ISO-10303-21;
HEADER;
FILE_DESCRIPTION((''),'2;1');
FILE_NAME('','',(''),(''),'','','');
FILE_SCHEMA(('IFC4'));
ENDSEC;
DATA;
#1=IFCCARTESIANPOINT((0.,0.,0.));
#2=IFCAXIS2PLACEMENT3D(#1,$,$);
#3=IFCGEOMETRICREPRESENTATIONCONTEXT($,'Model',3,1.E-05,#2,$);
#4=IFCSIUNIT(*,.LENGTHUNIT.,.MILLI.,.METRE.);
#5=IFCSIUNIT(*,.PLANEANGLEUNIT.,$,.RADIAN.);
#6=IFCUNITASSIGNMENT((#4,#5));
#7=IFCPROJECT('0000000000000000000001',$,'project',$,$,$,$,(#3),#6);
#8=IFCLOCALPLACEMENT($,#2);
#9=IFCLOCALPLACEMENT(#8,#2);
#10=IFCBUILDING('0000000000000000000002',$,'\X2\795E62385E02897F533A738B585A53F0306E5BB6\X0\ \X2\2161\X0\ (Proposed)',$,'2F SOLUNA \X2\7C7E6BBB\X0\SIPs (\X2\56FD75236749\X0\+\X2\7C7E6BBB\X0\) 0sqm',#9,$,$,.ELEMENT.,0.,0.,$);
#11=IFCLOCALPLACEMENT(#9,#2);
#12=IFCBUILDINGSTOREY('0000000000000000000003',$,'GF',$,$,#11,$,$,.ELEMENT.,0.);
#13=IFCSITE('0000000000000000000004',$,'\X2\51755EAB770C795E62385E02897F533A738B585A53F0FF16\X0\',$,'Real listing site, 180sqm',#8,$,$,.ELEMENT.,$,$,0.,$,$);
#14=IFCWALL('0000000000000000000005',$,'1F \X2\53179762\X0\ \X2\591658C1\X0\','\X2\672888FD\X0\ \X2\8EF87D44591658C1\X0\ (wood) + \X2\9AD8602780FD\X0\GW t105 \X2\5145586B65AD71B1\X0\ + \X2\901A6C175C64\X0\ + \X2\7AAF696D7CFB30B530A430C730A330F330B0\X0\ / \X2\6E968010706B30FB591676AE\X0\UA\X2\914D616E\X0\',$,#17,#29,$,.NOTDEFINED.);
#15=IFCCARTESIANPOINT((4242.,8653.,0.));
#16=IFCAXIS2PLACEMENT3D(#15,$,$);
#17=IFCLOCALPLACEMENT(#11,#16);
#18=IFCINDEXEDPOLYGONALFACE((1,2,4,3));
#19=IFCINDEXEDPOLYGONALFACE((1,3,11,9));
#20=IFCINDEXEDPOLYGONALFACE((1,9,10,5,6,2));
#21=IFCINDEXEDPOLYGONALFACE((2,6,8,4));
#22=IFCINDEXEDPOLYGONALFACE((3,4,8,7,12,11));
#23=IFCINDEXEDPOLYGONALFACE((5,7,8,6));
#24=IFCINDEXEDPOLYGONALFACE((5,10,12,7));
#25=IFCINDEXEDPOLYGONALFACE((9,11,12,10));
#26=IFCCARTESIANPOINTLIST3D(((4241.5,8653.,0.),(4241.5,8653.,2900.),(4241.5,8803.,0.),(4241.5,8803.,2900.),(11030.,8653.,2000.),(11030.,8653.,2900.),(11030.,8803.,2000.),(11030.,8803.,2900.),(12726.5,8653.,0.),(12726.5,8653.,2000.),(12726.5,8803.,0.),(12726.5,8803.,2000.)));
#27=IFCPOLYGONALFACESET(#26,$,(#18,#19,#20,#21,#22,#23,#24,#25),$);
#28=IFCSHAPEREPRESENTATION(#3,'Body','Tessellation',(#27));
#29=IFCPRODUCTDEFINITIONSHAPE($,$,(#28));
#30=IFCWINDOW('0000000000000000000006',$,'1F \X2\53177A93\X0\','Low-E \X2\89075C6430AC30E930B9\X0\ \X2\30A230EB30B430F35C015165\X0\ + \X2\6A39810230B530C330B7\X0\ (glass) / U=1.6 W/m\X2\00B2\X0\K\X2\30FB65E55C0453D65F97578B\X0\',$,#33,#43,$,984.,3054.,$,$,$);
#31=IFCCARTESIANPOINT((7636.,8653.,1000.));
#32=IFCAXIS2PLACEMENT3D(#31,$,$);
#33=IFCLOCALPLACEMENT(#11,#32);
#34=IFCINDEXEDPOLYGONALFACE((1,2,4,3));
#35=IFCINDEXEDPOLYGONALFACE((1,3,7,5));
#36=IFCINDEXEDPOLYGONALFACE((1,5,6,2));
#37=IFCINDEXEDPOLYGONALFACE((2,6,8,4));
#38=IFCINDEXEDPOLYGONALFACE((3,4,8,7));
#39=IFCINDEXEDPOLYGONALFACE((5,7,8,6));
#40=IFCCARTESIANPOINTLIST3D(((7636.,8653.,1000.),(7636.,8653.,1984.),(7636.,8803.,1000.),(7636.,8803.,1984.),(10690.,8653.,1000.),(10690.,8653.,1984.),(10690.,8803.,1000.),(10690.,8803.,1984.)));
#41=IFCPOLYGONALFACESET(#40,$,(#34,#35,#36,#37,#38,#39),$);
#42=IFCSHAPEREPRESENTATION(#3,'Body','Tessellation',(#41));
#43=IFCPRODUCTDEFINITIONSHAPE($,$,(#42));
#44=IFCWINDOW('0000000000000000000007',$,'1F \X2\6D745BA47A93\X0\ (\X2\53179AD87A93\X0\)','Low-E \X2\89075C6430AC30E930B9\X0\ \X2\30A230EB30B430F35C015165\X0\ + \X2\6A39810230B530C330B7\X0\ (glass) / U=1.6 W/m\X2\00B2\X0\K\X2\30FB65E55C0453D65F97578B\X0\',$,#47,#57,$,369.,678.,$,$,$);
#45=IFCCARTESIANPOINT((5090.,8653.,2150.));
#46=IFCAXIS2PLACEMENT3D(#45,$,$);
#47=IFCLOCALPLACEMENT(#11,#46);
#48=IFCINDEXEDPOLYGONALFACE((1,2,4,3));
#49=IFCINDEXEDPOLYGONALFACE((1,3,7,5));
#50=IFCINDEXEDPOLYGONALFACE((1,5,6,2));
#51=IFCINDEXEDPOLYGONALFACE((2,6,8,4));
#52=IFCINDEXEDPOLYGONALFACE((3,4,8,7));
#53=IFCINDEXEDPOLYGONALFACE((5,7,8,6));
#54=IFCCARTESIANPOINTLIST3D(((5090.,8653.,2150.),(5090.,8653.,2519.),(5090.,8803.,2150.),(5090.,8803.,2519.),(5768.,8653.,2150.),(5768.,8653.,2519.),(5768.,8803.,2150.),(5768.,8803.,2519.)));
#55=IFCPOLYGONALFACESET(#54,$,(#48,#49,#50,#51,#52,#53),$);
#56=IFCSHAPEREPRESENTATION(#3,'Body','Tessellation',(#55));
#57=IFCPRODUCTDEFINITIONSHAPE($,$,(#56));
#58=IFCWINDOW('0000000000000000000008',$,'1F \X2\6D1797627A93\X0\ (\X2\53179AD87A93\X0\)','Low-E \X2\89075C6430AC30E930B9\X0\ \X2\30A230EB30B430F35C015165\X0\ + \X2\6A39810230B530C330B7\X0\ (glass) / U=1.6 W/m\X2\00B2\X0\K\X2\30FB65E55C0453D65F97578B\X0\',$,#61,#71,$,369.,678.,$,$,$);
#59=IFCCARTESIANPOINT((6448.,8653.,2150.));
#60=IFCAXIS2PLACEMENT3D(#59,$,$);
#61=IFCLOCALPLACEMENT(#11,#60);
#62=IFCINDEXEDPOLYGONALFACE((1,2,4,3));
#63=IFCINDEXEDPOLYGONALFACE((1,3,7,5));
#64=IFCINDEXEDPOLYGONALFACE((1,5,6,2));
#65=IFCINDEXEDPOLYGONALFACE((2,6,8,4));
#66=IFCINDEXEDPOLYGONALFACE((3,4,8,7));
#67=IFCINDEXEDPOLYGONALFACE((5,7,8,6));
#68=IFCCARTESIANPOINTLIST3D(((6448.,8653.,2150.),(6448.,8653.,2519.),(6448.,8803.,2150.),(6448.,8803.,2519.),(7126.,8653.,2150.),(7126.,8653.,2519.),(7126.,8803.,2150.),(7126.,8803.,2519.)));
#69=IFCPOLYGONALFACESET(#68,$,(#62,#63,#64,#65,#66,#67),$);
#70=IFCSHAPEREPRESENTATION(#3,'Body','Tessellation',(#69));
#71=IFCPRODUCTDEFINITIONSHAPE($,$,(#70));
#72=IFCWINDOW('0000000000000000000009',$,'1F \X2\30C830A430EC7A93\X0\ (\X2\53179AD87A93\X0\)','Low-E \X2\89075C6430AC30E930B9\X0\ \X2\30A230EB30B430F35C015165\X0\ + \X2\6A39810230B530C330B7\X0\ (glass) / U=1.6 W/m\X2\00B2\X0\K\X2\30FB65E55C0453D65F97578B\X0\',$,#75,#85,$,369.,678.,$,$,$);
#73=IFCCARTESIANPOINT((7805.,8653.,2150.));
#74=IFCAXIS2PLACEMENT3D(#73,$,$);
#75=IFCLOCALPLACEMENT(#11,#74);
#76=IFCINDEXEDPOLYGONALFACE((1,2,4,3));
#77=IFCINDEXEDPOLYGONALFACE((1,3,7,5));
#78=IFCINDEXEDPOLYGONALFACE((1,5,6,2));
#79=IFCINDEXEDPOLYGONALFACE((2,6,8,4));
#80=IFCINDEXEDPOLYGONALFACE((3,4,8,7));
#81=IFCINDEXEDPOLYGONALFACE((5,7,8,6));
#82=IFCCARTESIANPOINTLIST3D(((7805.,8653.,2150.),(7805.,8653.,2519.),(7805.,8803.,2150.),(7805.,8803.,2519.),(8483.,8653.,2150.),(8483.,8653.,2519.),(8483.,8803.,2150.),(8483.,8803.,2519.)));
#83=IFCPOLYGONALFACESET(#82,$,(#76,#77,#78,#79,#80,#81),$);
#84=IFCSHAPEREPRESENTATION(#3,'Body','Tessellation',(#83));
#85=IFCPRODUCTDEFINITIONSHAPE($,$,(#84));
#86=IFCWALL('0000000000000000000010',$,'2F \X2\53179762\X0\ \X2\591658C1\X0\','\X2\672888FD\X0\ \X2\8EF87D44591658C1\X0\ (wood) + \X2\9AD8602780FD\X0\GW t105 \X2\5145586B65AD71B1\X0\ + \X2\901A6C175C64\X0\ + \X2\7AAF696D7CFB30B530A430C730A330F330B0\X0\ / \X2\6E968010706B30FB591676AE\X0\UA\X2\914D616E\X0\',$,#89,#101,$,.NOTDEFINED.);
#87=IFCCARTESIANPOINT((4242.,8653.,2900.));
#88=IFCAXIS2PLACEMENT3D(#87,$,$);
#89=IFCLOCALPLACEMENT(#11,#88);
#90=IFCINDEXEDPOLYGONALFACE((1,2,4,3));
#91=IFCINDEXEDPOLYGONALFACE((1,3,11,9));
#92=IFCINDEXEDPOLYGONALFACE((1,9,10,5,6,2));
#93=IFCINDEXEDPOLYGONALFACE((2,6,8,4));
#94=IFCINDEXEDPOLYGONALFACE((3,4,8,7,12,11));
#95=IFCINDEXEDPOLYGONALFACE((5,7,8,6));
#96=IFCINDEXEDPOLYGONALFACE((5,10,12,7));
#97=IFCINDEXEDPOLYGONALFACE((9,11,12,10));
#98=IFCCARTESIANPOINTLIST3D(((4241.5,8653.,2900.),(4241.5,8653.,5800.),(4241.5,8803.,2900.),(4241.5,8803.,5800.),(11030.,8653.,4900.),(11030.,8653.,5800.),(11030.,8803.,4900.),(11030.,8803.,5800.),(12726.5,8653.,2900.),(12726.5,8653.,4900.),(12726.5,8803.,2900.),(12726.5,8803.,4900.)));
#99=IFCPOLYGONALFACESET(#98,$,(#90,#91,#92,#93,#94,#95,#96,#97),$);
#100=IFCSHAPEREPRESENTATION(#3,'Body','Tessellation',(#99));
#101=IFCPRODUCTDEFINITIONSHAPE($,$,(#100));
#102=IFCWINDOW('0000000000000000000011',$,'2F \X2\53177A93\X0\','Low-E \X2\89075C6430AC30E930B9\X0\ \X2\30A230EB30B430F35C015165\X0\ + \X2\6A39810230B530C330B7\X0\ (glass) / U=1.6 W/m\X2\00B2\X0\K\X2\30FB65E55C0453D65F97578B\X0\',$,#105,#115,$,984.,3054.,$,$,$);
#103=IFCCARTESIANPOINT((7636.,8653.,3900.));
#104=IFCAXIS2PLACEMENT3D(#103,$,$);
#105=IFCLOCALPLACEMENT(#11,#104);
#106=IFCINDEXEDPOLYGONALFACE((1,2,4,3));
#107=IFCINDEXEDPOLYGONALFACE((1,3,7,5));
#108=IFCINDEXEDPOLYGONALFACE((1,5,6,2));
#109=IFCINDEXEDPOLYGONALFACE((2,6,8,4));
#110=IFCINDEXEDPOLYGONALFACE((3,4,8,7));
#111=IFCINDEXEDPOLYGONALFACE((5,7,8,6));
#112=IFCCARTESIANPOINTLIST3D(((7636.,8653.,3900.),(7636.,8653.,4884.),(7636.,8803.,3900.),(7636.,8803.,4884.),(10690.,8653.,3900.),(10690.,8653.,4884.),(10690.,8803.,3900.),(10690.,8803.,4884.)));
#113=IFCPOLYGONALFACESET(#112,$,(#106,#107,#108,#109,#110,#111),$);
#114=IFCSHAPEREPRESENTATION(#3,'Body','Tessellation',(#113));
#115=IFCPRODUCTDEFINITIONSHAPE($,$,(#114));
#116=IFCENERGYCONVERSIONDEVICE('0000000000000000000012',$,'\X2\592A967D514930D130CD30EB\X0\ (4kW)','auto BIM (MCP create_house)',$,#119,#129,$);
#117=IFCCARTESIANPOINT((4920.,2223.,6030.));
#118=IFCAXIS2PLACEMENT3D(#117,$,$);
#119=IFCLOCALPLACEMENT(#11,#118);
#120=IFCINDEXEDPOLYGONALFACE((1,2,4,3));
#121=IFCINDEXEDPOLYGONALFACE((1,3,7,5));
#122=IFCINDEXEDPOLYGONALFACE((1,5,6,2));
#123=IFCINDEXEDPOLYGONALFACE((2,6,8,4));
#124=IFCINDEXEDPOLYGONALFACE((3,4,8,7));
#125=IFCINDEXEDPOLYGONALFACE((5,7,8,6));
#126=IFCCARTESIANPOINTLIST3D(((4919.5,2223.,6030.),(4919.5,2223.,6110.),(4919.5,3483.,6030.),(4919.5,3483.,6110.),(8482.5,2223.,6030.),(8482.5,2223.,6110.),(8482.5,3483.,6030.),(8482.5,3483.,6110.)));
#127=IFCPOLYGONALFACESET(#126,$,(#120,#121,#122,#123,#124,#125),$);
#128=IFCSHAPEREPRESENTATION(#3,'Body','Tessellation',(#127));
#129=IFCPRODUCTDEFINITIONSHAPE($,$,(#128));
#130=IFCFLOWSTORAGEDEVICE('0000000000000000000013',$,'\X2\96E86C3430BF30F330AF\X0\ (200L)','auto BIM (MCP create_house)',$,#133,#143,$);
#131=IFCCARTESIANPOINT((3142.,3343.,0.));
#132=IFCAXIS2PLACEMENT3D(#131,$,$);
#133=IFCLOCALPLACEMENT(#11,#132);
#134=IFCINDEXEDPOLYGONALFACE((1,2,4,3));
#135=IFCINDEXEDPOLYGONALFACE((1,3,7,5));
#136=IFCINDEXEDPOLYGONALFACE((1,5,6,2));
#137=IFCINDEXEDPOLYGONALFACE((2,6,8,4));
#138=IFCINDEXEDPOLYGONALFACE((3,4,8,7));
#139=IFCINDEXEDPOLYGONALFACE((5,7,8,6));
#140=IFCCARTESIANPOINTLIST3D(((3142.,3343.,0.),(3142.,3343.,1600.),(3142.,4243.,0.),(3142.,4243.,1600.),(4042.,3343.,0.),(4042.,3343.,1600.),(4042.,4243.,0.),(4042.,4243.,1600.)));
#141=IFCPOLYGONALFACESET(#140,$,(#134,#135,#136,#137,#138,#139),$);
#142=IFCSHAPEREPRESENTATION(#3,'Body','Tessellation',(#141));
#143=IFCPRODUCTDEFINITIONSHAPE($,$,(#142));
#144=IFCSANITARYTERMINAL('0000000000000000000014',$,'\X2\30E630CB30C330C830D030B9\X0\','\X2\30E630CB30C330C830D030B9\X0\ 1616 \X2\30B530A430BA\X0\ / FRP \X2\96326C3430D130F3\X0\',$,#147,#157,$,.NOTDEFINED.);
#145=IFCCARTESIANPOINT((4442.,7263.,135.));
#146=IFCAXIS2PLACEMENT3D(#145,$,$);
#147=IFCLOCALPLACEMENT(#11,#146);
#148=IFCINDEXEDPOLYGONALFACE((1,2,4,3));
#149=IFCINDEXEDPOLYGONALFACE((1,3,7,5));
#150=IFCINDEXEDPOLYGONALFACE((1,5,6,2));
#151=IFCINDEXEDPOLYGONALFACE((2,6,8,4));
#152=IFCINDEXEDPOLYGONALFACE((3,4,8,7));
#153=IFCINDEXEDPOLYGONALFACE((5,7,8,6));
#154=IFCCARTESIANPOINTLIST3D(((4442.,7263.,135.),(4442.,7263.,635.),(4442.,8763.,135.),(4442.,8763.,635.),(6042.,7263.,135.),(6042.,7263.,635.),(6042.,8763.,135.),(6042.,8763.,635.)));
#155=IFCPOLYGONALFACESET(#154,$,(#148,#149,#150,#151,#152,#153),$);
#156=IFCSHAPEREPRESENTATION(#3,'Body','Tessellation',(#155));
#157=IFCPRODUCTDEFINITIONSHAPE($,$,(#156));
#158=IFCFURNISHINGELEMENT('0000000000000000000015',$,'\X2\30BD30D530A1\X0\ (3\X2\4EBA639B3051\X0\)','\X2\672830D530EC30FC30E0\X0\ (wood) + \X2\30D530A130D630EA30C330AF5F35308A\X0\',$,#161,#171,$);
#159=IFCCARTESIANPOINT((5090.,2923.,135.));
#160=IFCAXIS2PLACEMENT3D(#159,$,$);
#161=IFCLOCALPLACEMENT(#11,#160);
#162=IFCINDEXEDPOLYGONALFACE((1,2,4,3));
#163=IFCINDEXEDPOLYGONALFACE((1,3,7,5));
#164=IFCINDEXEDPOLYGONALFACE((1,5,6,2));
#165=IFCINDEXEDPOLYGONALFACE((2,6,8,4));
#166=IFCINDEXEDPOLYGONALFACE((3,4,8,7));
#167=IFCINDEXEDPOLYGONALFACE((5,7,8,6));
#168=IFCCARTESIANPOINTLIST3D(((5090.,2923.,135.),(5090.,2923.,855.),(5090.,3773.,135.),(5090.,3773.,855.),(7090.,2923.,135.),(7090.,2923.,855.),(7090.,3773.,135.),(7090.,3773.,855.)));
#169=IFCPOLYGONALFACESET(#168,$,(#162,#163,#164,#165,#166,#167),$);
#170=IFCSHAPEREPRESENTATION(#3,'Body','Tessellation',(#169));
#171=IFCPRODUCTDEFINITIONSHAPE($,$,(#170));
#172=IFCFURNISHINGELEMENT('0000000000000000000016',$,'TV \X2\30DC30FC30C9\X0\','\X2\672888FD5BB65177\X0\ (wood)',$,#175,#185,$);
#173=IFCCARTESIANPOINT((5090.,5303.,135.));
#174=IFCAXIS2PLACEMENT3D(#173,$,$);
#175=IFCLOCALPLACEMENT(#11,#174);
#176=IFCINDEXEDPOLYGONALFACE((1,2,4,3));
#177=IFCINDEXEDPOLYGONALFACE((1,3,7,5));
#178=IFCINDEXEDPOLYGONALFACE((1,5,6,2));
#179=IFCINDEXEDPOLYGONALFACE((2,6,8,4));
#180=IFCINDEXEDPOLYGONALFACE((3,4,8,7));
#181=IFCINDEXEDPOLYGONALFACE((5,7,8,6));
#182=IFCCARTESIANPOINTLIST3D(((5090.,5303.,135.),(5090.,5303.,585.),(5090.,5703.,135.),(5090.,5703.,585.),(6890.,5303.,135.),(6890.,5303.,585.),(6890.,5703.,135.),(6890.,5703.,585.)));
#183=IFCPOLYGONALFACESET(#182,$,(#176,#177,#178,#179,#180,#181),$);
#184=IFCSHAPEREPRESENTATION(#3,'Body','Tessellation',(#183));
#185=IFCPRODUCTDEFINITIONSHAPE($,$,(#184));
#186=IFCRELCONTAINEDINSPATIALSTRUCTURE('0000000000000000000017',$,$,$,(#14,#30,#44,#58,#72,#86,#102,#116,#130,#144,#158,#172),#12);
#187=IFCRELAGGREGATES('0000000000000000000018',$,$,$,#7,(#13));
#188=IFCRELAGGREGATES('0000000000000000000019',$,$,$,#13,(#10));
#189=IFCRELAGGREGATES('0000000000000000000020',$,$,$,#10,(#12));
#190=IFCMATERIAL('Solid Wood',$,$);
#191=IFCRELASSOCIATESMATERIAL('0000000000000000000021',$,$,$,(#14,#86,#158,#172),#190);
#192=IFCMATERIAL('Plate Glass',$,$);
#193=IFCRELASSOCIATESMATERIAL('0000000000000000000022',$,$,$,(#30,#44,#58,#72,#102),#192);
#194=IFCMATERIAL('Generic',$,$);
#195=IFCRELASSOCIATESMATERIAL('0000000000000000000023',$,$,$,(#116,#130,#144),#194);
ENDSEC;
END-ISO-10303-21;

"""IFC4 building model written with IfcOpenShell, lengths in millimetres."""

from ifc_helpers import new_model, si_unit, frame, frame_2d, origin, place, context, project, spatial, rectangle, extrude, material, element, fill, save


model = new_model("IFC4")

# Units and contexts
model_context = context("Model", 3, precision=1e-05, world=origin())
ifc_project = project(units=[si_unit("LENGTHUNIT", "METRE", prefix="MILLI"), si_unit("PLANEANGLEUNIT", "RADIAN")], contexts=[model_context])

# Site, building, storey
site_placement = place(None, origin())
site = spatial("IfcSite", under=ifc_project, at=site_placement, Name="兵庫県神戸市西区王塚台６", ObjectType="Real listing site, 180sqm", CompositionType="ELEMENT", RefElevation=0.0)
building_placement = place(site_placement, origin())
building = spatial("IfcBuilding", under=site, at=building_placement, Name="神戸市西区王塚台の家 Ⅱ (Proposed)", ObjectType="2F SOLUNA 籾殻SIPs (国産杉+籾殻) 0sqm", CompositionType="ELEMENT", ElevationOfRefHeight=0.0, ElevationOfTerrain=0.0)
storey_placement = place(building_placement, origin())
storey = spatial("IfcBuildingStorey", under=building, at=storey_placement, Name="GF", CompositionType="ELEMENT", Elevation=0.0)

# Wall, openings, windows
ifc_material_1 = material(Name="Solid Wood")
wall_1_placement = place(storey_placement, frame((4242.0, 8653.0, 0.0)))
wall_1 = element("IfcWall", 1, at=wall_1_placement, inside=storey, material=ifc_material_1, Name="1F 北面 外壁", Description="木製 軸組外壁 (wood) + 高性能GW t105 充填断熱 + 通気層 + 窯業系サイディング / 準耐火・外皮UA配慮", PredefinedType="NOTDEFINED", context=model_context, shape_type="SweptSolid", body=[
    extrude(rectangle(XDim=8485.0, YDim=150.0, at=frame_2d((4242.0, 75.0))), frame((4242.0, 8653.0, 0.0)), (0.0, 0.0, 1.0), 2900.0),
])
opening_1_placement = place(storey_placement, frame((7636.0, 8653.0, 1000.0)))
opening_1 = element("IfcOpeningElement", 2, at=opening_1_placement, cuts=wall_1, PredefinedType="NOTDEFINED", context=model_context, shape_type="SweptSolid", body=[
    extrude(rectangle(XDim=3054.0, YDim=150.0, at=frame_2d((1527.0, 75.0))), frame((7636.0, 8653.0, 1000.0)), (0.0, 0.0, 1.0), 984.0),
])
opening_2_placement = place(storey_placement, frame((5090.0, 8653.0, 2150.0)))
opening_2 = element("IfcOpeningElement", 3, at=opening_2_placement, cuts=wall_1, PredefinedType="NOTDEFINED", context=model_context, shape_type="SweptSolid", body=[
    extrude(rectangle(XDim=678.0, YDim=150.0, at=frame_2d((339.0, 75.0))), frame((5090.0, 8653.0, 2150.0)), (0.0, 0.0, 1.0), 369.0),
])
opening_3_placement = place(storey_placement, frame((6448.0, 8653.0, 2150.0)))
opening_3 = element("IfcOpeningElement", 4, at=opening_3_placement, cuts=wall_1, PredefinedType="NOTDEFINED", context=model_context, shape_type="SweptSolid", body=[
    extrude(rectangle(XDim=678.0, YDim=150.0, at=frame_2d((339.0, 75.0))), frame((6448.0, 8653.0, 2150.0)), (0.0, 0.0, 1.0), 369.0),
])
opening_4_placement = place(storey_placement, frame((7805.0, 8653.0, 2150.0)))
opening_4 = element("IfcOpeningElement", 5, at=opening_4_placement, cuts=wall_1, PredefinedType="NOTDEFINED", context=model_context, shape_type="SweptSolid", body=[
    extrude(rectangle(XDim=678.0, YDim=150.0, at=frame_2d((339.0, 75.0))), frame((7805.0, 8653.0, 2150.0)), (0.0, 0.0, 1.0), 369.0),
])
ifc_material_2 = material(Name="Plate Glass")
window_1_placement = place(storey_placement, frame((7636.0, 8653.0, 1000.0)))
window_1 = element("IfcWindow", 6, at=window_1_placement, inside=storey, material=ifc_material_2, Name="1F 北窓", Description="Low-E 複層ガラス アルゴン封入 + 樹脂サッシ (glass) / U=1.6 W/m²K・日射取得型", OverallHeight=984.0, OverallWidth=3054.0, context=model_context, shape_type="SweptSolid", body=[
    extrude(rectangle(XDim=3054.0, YDim=150.0, at=frame_2d((1527.0, 75.0))), frame((7636.0, 8653.0, 1000.0)), (0.0, 0.0, 1.0), 984.0),
])
fill(opening_1, window_1)
window_2_placement = place(storey_placement, frame((5090.0, 8653.0, 2150.0)))
window_2 = element("IfcWindow", 7, at=window_2_placement, inside=storey, material=ifc_material_2, Name="1F 浴室窓 (北高窓)", Description="Low-E 複層ガラス アルゴン封入 + 樹脂サッシ (glass) / U=1.6 W/m²K・日射取得型", OverallHeight=369.0, OverallWidth=678.0, context=model_context, shape_type="SweptSolid", body=[
    extrude(rectangle(XDim=678.0, YDim=150.0, at=frame_2d((339.0, 75.0))), frame((5090.0, 8653.0, 2150.0)), (0.0, 0.0, 1.0), 369.0),
])
fill(opening_2, window_2)
window_3_placement = place(storey_placement, frame((6448.0, 8653.0, 2150.0)))
window_3 = element("IfcWindow", 8, at=window_3_placement, inside=storey, material=ifc_material_2, Name="1F 洗面窓 (北高窓)", Description="Low-E 複層ガラス アルゴン封入 + 樹脂サッシ (glass) / U=1.6 W/m²K・日射取得型", OverallHeight=369.0, OverallWidth=678.0, context=model_context, shape_type="SweptSolid", body=[
    extrude(rectangle(XDim=678.0, YDim=150.0, at=frame_2d((339.0, 75.0))), frame((6448.0, 8653.0, 2150.0)), (0.0, 0.0, 1.0), 369.0),
])
fill(opening_3, window_3)
window_4_placement = place(storey_placement, frame((7805.0, 8653.0, 2150.0)))
window_4 = element("IfcWindow", 9, at=window_4_placement, inside=storey, material=ifc_material_2, Name="1F トイレ窓 (北高窓)", Description="Low-E 複層ガラス アルゴン封入 + 樹脂サッシ (glass) / U=1.6 W/m²K・日射取得型", OverallHeight=369.0, OverallWidth=678.0, context=model_context, shape_type="SweptSolid", body=[
    extrude(rectangle(XDim=678.0, YDim=150.0, at=frame_2d((339.0, 75.0))), frame((7805.0, 8653.0, 2150.0)), (0.0, 0.0, 1.0), 369.0),
])
fill(opening_4, window_4)

# Wall, opening, window
wall_2_placement = place(storey_placement, frame((4242.0, 8653.0, 2900.0)))
wall_2 = element("IfcWall", 10, at=wall_2_placement, inside=storey, material=ifc_material_1, Name="2F 北面 外壁", Description="木製 軸組外壁 (wood) + 高性能GW t105 充填断熱 + 通気層 + 窯業系サイディング / 準耐火・外皮UA配慮", PredefinedType="NOTDEFINED", context=model_context, shape_type="SweptSolid", body=[
    extrude(rectangle(XDim=8485.0, YDim=150.0, at=frame_2d((4242.0, 75.0))), frame((4242.0, 8653.0, 2900.0)), (0.0, 0.0, 1.0), 2900.0),
])
opening_5_placement = place(storey_placement, frame((7636.0, 8653.0, 3900.0)))
opening_5 = element("IfcOpeningElement", 11, at=opening_5_placement, cuts=wall_2, PredefinedType="NOTDEFINED", context=model_context, shape_type="SweptSolid", body=[
    extrude(rectangle(XDim=3054.0, YDim=150.0, at=frame_2d((1527.0, 75.0))), frame((7636.0, 8653.0, 3900.0)), (0.0, 0.0, 1.0), 984.0),
])
window_5_placement = place(storey_placement, frame((7636.0, 8653.0, 3900.0)))
window_5 = element("IfcWindow", 12, at=window_5_placement, inside=storey, material=ifc_material_2, Name="2F 北窓", Description="Low-E 複層ガラス アルゴン封入 + 樹脂サッシ (glass) / U=1.6 W/m²K・日射取得型", OverallHeight=984.0, OverallWidth=3054.0, context=model_context, shape_type="SweptSolid", body=[
    extrude(rectangle(XDim=3054.0, YDim=150.0, at=frame_2d((1527.0, 75.0))), frame((7636.0, 8653.0, 3900.0)), (0.0, 0.0, 1.0), 984.0),
])
fill(opening_5, window_5)

# Energy conversion device
ifc_material_3 = material(Name="Generic")
energy_conversion_device_placement = place(storey_placement, frame((4920.0, 2223.0, 6030.0)))
element("IfcEnergyConversionDevice", 13, at=energy_conversion_device_placement, inside=storey, material=ifc_material_3, Name="太陽光パネル (4kW)", Description="auto BIM (MCP create_house)", context=model_context, shape_type="SweptSolid", body=[
    extrude(rectangle(XDim=3563.0, YDim=1260.0, at=frame_2d((1781.0, 630.0))), frame((4920.0, 2223.0, 6030.0)), (0.0, 0.0, 1.0), 80.0),
])

# Flow storage device
flow_storage_device_placement = place(storey_placement, frame((3142.0, 3343.0, 0.0)))
element("IfcFlowStorageDevice", 14, at=flow_storage_device_placement, inside=storey, material=ifc_material_3, Name="雨水タンク (200L)", Description="auto BIM (MCP create_house)", context=model_context, shape_type="SweptSolid", body=[
    extrude(rectangle(XDim=900.0, YDim=900.0, at=frame_2d((450.0, 450.0))), frame((3142.0, 3343.0, 0.0)), (0.0, 0.0, 1.0), 1600.0),
])

# Sanitary terminal
sanitary_terminal_placement = place(storey_placement, frame((4442.0, 7263.0, 135.0)))
element("IfcSanitaryTerminal", 15, at=sanitary_terminal_placement, inside=storey, material=ifc_material_3, Name="ユニットバス", Description="ユニットバス 1616 サイズ / FRP 防水パン", PredefinedType="NOTDEFINED", context=model_context, shape_type="SweptSolid", body=[
    extrude(rectangle(XDim=1600.0, YDim=1500.0, at=frame_2d((800.0, 750.0))), frame((4442.0, 7263.0, 135.0)), (0.0, 0.0, 1.0), 500.0),
])

# Furnishing elements
furnishing_1_placement = place(storey_placement, frame((5090.0, 2923.0, 135.0)))
element("IfcFurnishingElement", 16, at=furnishing_1_placement, inside=storey, material=ifc_material_1, Name="ソファ (3人掛け)", Description="木フレーム (wood) + ファブリック張り", context=model_context, shape_type="SweptSolid", body=[
    extrude(rectangle(XDim=2000.0, YDim=850.0, at=frame_2d((1000.0, 425.0))), frame((5090.0, 2923.0, 135.0)), (0.0, 0.0, 1.0), 720.0),
])
furnishing_2_placement = place(storey_placement, frame((5090.0, 5303.0, 135.0)))
element("IfcFurnishingElement", 17, at=furnishing_2_placement, inside=storey, material=ifc_material_1, Name="TV ボード", Description="木製家具 (wood)", context=model_context, shape_type="SweptSolid", body=[
    extrude(rectangle(XDim=1800.0, YDim=400.0, at=frame_2d((900.0, 200.0))), frame((5090.0, 5303.0, 135.0)), (0.0, 0.0, 1.0), 450.0),
])

save(model, "model.ifc")
